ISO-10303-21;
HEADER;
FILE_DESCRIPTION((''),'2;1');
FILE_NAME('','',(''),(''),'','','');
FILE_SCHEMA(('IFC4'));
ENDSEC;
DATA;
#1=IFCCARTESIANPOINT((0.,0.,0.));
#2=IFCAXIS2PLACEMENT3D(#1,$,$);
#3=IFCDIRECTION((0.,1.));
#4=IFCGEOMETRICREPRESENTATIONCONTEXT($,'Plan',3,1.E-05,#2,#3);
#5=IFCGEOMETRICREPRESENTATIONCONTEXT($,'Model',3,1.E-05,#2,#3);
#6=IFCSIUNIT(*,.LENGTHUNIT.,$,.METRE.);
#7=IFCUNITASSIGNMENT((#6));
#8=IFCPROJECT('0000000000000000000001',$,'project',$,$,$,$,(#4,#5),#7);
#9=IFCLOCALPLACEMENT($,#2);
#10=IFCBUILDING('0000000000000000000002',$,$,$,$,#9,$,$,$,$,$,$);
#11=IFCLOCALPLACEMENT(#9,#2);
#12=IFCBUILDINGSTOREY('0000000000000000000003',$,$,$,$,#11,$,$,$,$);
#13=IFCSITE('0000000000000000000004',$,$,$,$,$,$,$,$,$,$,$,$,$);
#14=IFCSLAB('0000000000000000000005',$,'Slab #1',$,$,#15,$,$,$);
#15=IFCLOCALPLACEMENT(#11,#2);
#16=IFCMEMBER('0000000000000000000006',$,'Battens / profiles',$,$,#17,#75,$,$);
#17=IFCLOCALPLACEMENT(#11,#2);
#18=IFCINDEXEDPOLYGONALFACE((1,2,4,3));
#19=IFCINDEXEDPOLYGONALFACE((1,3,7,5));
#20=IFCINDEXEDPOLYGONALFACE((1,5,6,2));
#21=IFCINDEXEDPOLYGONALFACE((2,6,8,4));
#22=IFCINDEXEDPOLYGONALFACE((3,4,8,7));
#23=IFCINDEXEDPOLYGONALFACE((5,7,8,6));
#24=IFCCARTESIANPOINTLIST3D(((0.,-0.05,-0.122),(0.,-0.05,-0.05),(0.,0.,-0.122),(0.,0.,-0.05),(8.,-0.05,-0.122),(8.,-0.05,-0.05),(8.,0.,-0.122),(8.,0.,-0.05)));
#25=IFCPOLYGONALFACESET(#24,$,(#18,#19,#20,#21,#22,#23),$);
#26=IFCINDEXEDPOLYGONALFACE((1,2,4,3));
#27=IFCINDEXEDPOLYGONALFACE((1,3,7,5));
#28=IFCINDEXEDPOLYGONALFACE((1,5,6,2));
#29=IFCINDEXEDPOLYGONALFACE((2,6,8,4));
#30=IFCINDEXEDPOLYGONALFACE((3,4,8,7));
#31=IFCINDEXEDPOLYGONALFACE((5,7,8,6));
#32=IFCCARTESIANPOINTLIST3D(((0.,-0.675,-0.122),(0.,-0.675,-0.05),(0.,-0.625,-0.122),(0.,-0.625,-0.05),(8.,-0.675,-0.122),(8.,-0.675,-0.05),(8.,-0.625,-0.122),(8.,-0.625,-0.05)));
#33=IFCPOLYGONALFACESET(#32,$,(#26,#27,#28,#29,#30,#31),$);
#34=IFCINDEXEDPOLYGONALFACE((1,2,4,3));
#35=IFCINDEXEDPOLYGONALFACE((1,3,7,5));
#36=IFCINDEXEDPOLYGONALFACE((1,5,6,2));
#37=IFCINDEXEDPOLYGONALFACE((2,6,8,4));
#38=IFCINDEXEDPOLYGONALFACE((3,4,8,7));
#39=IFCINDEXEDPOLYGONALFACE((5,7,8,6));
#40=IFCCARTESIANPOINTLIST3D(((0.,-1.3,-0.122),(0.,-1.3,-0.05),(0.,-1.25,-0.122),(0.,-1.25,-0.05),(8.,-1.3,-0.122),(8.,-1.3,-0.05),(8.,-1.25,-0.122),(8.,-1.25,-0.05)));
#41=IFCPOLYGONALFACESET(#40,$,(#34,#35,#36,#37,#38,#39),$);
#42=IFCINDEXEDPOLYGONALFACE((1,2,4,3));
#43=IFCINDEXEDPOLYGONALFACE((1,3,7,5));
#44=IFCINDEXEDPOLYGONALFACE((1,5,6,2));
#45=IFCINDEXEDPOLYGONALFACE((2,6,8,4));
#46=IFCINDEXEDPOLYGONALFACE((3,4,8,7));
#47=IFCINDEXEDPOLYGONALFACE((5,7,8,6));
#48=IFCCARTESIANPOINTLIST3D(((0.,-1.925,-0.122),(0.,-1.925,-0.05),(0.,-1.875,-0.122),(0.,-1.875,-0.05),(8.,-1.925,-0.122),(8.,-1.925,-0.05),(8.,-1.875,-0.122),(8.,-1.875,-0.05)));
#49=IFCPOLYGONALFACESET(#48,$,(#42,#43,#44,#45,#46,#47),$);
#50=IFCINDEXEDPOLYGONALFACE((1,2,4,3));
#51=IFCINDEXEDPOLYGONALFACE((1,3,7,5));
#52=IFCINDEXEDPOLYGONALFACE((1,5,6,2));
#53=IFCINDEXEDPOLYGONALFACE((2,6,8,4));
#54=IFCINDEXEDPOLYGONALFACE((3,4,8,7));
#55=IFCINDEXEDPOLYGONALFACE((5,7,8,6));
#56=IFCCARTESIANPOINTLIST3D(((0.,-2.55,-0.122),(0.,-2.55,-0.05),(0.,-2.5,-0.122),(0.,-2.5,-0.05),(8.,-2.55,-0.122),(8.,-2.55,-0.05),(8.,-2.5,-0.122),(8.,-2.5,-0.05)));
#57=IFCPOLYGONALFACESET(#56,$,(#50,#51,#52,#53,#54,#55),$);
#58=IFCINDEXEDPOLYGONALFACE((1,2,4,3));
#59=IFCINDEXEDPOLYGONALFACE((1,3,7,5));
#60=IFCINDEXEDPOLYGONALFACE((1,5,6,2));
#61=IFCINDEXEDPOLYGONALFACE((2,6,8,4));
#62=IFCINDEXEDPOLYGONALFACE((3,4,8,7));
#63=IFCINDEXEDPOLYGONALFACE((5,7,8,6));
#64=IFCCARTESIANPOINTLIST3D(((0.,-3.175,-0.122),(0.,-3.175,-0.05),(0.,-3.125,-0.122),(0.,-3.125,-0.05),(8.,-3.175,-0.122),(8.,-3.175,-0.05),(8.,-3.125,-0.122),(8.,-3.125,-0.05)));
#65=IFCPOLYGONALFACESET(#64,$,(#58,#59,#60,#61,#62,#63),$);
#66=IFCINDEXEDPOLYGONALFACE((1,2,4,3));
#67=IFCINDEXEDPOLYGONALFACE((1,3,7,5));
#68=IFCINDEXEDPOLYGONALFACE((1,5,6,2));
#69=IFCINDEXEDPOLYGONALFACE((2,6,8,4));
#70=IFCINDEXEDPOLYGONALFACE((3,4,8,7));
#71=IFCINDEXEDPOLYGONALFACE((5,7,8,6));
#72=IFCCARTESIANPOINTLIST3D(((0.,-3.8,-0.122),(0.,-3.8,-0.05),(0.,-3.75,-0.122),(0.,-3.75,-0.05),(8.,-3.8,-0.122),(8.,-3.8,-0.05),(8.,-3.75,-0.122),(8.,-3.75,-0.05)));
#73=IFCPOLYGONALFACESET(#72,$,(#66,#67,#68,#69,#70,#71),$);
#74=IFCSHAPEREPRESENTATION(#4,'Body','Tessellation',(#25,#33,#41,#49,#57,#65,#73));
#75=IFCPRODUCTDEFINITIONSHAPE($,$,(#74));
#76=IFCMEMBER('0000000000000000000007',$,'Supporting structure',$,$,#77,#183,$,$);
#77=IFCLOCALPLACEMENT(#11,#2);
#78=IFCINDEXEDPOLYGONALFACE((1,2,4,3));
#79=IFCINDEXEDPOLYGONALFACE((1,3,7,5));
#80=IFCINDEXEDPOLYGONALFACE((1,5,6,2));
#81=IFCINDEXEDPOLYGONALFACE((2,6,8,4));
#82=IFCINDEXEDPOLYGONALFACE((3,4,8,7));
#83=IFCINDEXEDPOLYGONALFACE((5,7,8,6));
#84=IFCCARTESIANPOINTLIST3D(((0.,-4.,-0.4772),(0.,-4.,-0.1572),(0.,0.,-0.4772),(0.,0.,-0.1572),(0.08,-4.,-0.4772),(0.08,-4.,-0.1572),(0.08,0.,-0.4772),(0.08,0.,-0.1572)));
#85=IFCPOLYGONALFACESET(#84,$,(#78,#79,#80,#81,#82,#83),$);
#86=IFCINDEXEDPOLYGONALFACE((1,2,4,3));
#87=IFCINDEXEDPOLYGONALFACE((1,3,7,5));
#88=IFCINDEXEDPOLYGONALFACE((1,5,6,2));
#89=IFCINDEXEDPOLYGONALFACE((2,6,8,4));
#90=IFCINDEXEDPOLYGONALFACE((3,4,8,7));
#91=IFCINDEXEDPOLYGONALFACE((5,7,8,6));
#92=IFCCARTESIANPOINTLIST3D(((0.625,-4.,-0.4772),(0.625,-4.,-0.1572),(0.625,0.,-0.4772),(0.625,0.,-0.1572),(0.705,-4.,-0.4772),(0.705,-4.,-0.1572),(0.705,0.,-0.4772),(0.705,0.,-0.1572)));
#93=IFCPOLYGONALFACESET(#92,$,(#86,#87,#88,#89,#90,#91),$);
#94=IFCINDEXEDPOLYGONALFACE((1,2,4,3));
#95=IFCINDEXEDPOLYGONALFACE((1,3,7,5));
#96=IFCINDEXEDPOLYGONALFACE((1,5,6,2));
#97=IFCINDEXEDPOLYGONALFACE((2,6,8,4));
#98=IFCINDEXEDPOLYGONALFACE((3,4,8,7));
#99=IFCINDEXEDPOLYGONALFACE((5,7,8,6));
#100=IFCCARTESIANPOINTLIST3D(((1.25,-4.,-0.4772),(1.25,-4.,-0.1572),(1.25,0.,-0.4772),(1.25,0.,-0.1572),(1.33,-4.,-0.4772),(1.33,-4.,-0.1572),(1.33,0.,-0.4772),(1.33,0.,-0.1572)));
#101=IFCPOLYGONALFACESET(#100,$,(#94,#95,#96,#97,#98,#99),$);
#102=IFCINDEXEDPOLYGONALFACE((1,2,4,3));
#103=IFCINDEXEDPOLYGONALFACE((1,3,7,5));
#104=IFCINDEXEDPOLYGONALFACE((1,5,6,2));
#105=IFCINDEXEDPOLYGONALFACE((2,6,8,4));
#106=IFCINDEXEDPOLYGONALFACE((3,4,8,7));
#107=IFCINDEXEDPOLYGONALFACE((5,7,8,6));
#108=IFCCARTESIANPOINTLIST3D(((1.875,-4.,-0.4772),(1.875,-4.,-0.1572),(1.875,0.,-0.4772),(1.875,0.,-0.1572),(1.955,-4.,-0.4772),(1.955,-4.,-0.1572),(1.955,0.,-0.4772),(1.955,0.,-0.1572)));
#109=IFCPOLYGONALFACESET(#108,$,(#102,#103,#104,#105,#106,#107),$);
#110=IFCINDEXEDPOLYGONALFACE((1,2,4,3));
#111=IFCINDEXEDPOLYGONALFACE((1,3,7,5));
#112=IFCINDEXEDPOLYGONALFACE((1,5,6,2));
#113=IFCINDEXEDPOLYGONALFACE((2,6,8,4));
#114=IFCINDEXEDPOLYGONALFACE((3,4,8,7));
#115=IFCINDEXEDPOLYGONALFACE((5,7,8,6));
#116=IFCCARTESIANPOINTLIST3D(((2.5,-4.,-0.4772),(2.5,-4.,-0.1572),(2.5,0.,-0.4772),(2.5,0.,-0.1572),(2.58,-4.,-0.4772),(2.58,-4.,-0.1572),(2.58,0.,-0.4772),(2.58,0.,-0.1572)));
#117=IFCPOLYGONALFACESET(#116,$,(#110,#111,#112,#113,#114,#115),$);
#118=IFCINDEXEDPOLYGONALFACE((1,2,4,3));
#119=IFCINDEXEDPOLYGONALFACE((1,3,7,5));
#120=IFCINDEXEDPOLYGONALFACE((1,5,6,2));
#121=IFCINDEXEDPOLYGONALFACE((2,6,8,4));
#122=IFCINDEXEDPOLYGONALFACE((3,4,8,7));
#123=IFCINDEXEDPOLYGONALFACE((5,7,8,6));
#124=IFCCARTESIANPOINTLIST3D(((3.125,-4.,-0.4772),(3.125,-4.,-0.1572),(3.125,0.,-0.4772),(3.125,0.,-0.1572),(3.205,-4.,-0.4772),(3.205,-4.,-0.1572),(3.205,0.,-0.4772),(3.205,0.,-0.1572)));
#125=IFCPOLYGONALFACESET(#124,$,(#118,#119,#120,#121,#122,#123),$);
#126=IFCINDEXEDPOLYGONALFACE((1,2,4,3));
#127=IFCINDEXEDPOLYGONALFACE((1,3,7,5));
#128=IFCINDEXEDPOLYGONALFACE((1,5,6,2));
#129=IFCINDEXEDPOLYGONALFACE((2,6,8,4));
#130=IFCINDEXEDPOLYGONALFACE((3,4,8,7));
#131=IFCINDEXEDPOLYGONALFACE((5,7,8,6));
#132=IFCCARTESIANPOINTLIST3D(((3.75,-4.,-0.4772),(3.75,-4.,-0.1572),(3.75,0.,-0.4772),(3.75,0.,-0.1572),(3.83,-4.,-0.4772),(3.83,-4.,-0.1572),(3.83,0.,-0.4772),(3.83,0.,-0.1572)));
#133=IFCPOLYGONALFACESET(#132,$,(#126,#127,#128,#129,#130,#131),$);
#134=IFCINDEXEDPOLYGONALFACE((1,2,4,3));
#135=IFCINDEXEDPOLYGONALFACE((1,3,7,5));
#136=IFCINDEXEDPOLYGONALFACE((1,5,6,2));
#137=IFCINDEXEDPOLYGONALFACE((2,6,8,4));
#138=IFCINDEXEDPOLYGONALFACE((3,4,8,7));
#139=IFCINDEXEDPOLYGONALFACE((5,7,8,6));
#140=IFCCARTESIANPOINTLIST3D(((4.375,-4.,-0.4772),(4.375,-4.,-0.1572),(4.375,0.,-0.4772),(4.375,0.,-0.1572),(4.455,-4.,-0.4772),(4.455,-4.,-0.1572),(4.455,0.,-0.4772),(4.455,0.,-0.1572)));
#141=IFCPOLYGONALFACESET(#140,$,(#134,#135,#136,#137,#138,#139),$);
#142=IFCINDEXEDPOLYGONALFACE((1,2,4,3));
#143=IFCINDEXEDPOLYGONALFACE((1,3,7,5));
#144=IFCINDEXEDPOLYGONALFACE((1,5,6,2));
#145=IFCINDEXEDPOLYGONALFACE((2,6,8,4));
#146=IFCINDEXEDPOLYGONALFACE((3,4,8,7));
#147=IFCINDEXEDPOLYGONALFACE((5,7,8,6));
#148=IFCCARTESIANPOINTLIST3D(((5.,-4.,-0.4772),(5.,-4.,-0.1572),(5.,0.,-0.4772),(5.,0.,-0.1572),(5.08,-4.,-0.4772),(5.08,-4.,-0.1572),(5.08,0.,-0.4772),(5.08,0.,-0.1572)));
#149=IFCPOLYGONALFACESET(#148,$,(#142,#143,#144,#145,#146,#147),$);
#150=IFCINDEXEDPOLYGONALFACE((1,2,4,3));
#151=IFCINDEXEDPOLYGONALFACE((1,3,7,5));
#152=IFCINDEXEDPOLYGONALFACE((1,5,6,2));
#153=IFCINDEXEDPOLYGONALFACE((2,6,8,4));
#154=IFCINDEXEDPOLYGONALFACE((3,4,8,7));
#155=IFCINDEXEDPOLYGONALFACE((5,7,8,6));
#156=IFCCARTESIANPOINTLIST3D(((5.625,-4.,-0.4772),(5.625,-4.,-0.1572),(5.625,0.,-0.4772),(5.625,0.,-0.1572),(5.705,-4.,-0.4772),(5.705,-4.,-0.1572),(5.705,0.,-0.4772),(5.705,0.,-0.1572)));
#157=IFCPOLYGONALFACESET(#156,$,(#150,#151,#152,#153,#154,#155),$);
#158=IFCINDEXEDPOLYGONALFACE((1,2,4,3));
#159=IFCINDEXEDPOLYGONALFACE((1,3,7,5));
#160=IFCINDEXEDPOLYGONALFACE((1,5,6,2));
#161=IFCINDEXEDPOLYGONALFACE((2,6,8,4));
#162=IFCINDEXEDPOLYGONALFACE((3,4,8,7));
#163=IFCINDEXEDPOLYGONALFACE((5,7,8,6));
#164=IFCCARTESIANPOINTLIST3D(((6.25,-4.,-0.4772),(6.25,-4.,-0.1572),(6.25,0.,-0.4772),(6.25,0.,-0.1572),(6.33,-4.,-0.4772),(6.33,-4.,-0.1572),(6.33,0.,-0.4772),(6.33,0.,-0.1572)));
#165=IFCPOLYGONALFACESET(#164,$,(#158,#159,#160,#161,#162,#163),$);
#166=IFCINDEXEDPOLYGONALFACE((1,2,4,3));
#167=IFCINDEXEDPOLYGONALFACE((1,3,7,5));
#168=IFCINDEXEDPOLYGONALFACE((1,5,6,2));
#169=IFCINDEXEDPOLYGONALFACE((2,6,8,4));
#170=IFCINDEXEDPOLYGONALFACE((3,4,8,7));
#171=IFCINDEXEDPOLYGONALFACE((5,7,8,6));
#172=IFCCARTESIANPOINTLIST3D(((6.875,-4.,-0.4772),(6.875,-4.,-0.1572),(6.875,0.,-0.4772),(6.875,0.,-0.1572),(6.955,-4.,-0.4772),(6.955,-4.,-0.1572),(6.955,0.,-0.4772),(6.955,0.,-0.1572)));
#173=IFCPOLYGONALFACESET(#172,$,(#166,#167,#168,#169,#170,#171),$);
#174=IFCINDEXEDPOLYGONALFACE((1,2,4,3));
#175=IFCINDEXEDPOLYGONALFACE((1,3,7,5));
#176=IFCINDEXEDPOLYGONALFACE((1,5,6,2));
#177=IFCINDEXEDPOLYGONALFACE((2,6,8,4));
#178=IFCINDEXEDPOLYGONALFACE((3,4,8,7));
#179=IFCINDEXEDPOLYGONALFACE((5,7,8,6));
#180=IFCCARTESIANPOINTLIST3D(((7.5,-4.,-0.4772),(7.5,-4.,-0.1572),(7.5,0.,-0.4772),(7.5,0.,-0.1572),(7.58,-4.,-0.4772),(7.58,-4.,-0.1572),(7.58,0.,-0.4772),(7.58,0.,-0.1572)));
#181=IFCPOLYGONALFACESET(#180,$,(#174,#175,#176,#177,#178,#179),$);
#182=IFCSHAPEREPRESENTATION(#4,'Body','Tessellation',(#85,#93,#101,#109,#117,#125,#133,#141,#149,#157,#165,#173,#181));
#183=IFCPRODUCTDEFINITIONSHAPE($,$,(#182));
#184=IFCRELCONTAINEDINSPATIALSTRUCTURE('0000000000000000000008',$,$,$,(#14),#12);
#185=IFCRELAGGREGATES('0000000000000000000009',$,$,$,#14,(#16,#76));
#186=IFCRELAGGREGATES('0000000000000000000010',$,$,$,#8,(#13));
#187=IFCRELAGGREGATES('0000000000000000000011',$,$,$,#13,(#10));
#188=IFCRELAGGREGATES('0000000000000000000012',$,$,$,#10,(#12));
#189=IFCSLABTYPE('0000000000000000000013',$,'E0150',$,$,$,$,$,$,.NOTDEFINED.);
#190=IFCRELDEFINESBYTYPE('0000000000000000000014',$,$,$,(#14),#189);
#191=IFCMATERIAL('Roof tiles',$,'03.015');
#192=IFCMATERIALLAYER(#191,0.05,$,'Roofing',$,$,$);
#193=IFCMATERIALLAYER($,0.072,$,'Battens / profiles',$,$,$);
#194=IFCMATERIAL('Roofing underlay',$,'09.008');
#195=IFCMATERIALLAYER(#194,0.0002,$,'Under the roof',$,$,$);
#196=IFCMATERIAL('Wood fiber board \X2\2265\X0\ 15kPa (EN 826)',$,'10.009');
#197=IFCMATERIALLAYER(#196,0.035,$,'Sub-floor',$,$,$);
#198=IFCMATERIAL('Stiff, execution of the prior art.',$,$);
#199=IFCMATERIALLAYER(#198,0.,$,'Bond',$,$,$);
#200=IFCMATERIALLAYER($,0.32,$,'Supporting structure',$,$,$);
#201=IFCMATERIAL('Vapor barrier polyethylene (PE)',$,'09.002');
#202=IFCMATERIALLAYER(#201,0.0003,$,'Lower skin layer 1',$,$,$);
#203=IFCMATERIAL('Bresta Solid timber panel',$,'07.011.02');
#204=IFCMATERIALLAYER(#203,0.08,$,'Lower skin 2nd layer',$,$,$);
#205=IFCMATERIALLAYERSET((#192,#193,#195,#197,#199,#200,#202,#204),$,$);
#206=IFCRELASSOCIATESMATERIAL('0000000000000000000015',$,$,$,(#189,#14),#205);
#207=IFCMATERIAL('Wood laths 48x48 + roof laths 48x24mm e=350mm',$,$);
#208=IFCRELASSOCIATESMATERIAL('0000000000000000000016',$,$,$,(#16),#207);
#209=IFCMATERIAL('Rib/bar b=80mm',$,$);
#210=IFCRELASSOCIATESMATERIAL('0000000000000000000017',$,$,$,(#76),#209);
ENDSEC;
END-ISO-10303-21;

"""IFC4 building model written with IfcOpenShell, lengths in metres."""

from ifc_helpers import new_model, si_unit, direction, frame, frame_2d, origin, place, context, project, spatial, rectangle, extrude, material, layer, layer_set, type_object, element, aggregate, save


model = new_model("IFC4")

# Units and contexts
plan_context = context("Plan", 3, precision=1e-05, world=origin(), true_north=direction((0.0, 1.0)))
model_context = context("Model", 3, precision=1e-05, world=origin(), true_north=direction((0.0, 1.0)))
ifc_project = project(units=[si_unit("LENGTHUNIT", "METRE")], contexts=[plan_context, model_context])

# Site, building, storey
site = spatial("IfcSite", under=ifc_project)
building_placement = place(None, origin())
building = spatial("IfcBuilding", under=site, at=building_placement)
storey_placement = place(building_placement, origin())
storey = spatial("IfcBuildingStorey", under=building, at=storey_placement)

# Slab, members
ifc_material_1 = material(Name="Roof tiles", Category="03.015")
ifc_layer_1 = layer(ifc_material_1, 0.05, Name="Roofing")
ifc_layer_2 = layer(None, 0.072, Name="Battens / profiles")
ifc_material_2 = material(Name="Roofing underlay", Category="09.008")
ifc_layer_3 = layer(ifc_material_2, 0.0002, Name="Under the roof")
ifc_material_3 = material(Name="Wood fiber board ≥ 15kPa (EN 826)", Category="10.009")
ifc_layer_4 = layer(ifc_material_3, 0.035, Name="Sub-floor")
ifc_material_4 = material(Name="Stiff, execution of the prior art.")
ifc_layer_5 = layer(ifc_material_4, 0.0, Name="Bond")
ifc_layer_6 = layer(None, 0.32, Name="Supporting structure")
ifc_material_5 = material(Name="Vapor barrier polyethylene (PE)", Category="09.002")
ifc_layer_7 = layer(ifc_material_5, 0.0003, Name="Lower skin layer 1")
ifc_material_6 = material(Name="Bresta Solid timber panel", Category="07.011.02")
ifc_layer_8 = layer(ifc_material_6, 0.08, Name="Lower skin 2nd layer")
ifc_layer_set = layer_set([ifc_layer_1, ifc_layer_2, ifc_layer_3, ifc_layer_4, ifc_layer_5, ifc_layer_6, ifc_layer_7, ifc_layer_8])
slab_type = type_object("IfcSlabType", Name="E0150", PredefinedType="NOTDEFINED", material=ifc_layer_set)
slab_placement = place(None, frame((0.0, 0.0, 0.0), z_axis=(0.0, 0.0, -1.0), x_axis=(1.0, 0.0, 0.0)))
slab = element("IfcSlab", 1, at=slab_placement, inside=storey, type_object=slab_type, material=ifc_layer_set, Name="Slab #1")
ifc_material_7 = material(Name="Wood laths 48x48 + roof laths 48x24mm e=350mm")
member_1_placement = place(slab_placement, origin())
member_1 = element("IfcMember", 2, at=member_1_placement, material=ifc_material_7, Name="Battens / profiles", context=plan_context, shape_type="SweptSolid", body=[
    extrude(rectangle(XDim=0.05, YDim=0.072, at=frame_2d((0.025, 0.036), x_axis=(1.0, 0.0))), frame((0.0, 0.0, 0.05), z_axis=(1.0, 0.0, 0.0), x_axis=(0.0, 1.0, 0.0)), (0.0, 0.0, 1.0), 8.0),
    extrude(rectangle(XDim=0.05, YDim=0.072, at=frame_2d((0.025, 0.036), x_axis=(1.0, 0.0))), frame((0.0, 0.625, 0.05), z_axis=(1.0, 0.0, 0.0), x_axis=(0.0, 1.0, 0.0)), (0.0, 0.0, 1.0), 8.0),
    extrude(rectangle(XDim=0.05, YDim=0.072, at=frame_2d((0.025, 0.036), x_axis=(1.0, 0.0))), frame((0.0, 1.25, 0.05), z_axis=(1.0, 0.0, 0.0), x_axis=(0.0, 1.0, 0.0)), (0.0, 0.0, 1.0), 8.0),
    extrude(rectangle(XDim=0.05, YDim=0.072, at=frame_2d((0.025, 0.036), x_axis=(1.0, 0.0))), frame((0.0, 1.875, 0.05), z_axis=(1.0, 0.0, 0.0), x_axis=(0.0, 1.0, 0.0)), (0.0, 0.0, 1.0), 8.0),
    extrude(rectangle(XDim=0.05, YDim=0.072, at=frame_2d((0.025, 0.036), x_axis=(1.0, 0.0))), frame((0.0, 2.5, 0.05), z_axis=(1.0, 0.0, 0.0), x_axis=(0.0, 1.0, 0.0)), (0.0, 0.0, 1.0), 8.0),
    extrude(rectangle(XDim=0.05, YDim=0.072, at=frame_2d((0.025, 0.036), x_axis=(1.0, 0.0))), frame((0.0, 3.125, 0.05), z_axis=(1.0, 0.0, 0.0), x_axis=(0.0, 1.0, 0.0)), (0.0, 0.0, 1.0), 8.0),
    extrude(rectangle(XDim=0.05, YDim=0.072, at=frame_2d((0.025, 0.036), x_axis=(1.0, 0.0))), frame((0.0, 3.75, 0.05), z_axis=(1.0, 0.0, 0.0), x_axis=(0.0, 1.0, 0.0)), (0.0, 0.0, 1.0), 8.0),
])
ifc_material_8 = material(Name="Rib/bar b=80mm")
member_2_placement = place(slab_placement, origin())
member_2 = element("IfcMember", 3, at=member_2_placement, material=ifc_material_8, Name="Supporting structure", context=plan_context, shape_type="SweptSolid", body=[
    extrude(rectangle(XDim=0.08, YDim=0.32, at=frame_2d((0.04, 0.16), x_axis=(1.0, 0.0))), frame((0.0, 4.0, 0.1572), z_axis=(0.0, -1.0, 0.0), x_axis=(1.0, 0.0, 0.0)), (0.0, 0.0, 1.0), 4.0),
    extrude(rectangle(XDim=0.08, YDim=0.32, at=frame_2d((0.04, 0.16), x_axis=(1.0, 0.0))), frame((0.625, 4.0, 0.1572), z_axis=(0.0, -1.0, 0.0), x_axis=(1.0, 0.0, 0.0)), (0.0, 0.0, 1.0), 4.0),
    extrude(rectangle(XDim=0.08, YDim=0.32, at=frame_2d((0.04, 0.16), x_axis=(1.0, 0.0))), frame((1.25, 4.0, 0.1572), z_axis=(0.0, -1.0, 0.0), x_axis=(1.0, 0.0, 0.0)), (0.0, 0.0, 1.0), 4.0),
    extrude(rectangle(XDim=0.08, YDim=0.32, at=frame_2d((0.04, 0.16), x_axis=(1.0, 0.0))), frame((1.875, 4.0, 0.1572), z_axis=(0.0, -1.0, 0.0), x_axis=(1.0, 0.0, 0.0)), (0.0, 0.0, 1.0), 4.0),
    extrude(rectangle(XDim=0.08, YDim=0.32, at=frame_2d((0.04, 0.16), x_axis=(1.0, 0.0))), frame((2.5, 4.0, 0.1572), z_axis=(0.0, -1.0, 0.0), x_axis=(1.0, 0.0, 0.0)), (0.0, 0.0, 1.0), 4.0),
    extrude(rectangle(XDim=0.08, YDim=0.32, at=frame_2d((0.04, 0.16), x_axis=(1.0, 0.0))), frame((3.125, 4.0, 0.1572), z_axis=(0.0, -1.0, 0.0), x_axis=(1.0, 0.0, 0.0)), (0.0, 0.0, 1.0), 4.0),
    extrude(rectangle(XDim=0.08, YDim=0.32, at=frame_2d((0.04, 0.16), x_axis=(1.0, 0.0))), frame((3.75, 4.0, 0.1572), z_axis=(0.0, -1.0, 0.0), x_axis=(1.0, 0.0, 0.0)), (0.0, 0.0, 1.0), 4.0),
    extrude(rectangle(XDim=0.08, YDim=0.32, at=frame_2d((0.04, 0.16), x_axis=(1.0, 0.0))), frame((4.375, 4.0, 0.1572), z_axis=(0.0, -1.0, 0.0), x_axis=(1.0, 0.0, 0.0)), (0.0, 0.0, 1.0), 4.0),
    extrude(rectangle(XDim=0.08, YDim=0.32, at=frame_2d((0.04, 0.16), x_axis=(1.0, 0.0))), frame((5.0, 4.0, 0.1572), z_axis=(0.0, -1.0, 0.0), x_axis=(1.0, 0.0, 0.0)), (0.0, 0.0, 1.0), 4.0),
    extrude(rectangle(XDim=0.08, YDim=0.32, at=frame_2d((0.04, 0.16), x_axis=(1.0, 0.0))), frame((5.625, 4.0, 0.1572), z_axis=(0.0, -1.0, 0.0), x_axis=(1.0, 0.0, 0.0)), (0.0, 0.0, 1.0), 4.0),
    extrude(rectangle(XDim=0.08, YDim=0.32, at=frame_2d((0.04, 0.16), x_axis=(1.0, 0.0))), frame((6.25, 4.0, 0.1572), z_axis=(0.0, -1.0, 0.0), x_axis=(1.0, 0.0, 0.0)), (0.0, 0.0, 1.0), 4.0),
    extrude(rectangle(XDim=0.08, YDim=0.32, at=frame_2d((0.04, 0.16), x_axis=(1.0, 0.0))), frame((6.875, 4.0, 0.1572), z_axis=(0.0, -1.0, 0.0), x_axis=(1.0, 0.0, 0.0)), (0.0, 0.0, 1.0), 4.0),
    extrude(rectangle(XDim=0.08, YDim=0.32, at=frame_2d((0.04, 0.16), x_axis=(1.0, 0.0))), frame((7.5, 4.0, 0.1572), z_axis=(0.0, -1.0, 0.0), x_axis=(1.0, 0.0, 0.0)), (0.0, 0.0, 1.0), 4.0),
])
aggregate(slab, [member_1, member_2])

save(model, "model.ifc")
